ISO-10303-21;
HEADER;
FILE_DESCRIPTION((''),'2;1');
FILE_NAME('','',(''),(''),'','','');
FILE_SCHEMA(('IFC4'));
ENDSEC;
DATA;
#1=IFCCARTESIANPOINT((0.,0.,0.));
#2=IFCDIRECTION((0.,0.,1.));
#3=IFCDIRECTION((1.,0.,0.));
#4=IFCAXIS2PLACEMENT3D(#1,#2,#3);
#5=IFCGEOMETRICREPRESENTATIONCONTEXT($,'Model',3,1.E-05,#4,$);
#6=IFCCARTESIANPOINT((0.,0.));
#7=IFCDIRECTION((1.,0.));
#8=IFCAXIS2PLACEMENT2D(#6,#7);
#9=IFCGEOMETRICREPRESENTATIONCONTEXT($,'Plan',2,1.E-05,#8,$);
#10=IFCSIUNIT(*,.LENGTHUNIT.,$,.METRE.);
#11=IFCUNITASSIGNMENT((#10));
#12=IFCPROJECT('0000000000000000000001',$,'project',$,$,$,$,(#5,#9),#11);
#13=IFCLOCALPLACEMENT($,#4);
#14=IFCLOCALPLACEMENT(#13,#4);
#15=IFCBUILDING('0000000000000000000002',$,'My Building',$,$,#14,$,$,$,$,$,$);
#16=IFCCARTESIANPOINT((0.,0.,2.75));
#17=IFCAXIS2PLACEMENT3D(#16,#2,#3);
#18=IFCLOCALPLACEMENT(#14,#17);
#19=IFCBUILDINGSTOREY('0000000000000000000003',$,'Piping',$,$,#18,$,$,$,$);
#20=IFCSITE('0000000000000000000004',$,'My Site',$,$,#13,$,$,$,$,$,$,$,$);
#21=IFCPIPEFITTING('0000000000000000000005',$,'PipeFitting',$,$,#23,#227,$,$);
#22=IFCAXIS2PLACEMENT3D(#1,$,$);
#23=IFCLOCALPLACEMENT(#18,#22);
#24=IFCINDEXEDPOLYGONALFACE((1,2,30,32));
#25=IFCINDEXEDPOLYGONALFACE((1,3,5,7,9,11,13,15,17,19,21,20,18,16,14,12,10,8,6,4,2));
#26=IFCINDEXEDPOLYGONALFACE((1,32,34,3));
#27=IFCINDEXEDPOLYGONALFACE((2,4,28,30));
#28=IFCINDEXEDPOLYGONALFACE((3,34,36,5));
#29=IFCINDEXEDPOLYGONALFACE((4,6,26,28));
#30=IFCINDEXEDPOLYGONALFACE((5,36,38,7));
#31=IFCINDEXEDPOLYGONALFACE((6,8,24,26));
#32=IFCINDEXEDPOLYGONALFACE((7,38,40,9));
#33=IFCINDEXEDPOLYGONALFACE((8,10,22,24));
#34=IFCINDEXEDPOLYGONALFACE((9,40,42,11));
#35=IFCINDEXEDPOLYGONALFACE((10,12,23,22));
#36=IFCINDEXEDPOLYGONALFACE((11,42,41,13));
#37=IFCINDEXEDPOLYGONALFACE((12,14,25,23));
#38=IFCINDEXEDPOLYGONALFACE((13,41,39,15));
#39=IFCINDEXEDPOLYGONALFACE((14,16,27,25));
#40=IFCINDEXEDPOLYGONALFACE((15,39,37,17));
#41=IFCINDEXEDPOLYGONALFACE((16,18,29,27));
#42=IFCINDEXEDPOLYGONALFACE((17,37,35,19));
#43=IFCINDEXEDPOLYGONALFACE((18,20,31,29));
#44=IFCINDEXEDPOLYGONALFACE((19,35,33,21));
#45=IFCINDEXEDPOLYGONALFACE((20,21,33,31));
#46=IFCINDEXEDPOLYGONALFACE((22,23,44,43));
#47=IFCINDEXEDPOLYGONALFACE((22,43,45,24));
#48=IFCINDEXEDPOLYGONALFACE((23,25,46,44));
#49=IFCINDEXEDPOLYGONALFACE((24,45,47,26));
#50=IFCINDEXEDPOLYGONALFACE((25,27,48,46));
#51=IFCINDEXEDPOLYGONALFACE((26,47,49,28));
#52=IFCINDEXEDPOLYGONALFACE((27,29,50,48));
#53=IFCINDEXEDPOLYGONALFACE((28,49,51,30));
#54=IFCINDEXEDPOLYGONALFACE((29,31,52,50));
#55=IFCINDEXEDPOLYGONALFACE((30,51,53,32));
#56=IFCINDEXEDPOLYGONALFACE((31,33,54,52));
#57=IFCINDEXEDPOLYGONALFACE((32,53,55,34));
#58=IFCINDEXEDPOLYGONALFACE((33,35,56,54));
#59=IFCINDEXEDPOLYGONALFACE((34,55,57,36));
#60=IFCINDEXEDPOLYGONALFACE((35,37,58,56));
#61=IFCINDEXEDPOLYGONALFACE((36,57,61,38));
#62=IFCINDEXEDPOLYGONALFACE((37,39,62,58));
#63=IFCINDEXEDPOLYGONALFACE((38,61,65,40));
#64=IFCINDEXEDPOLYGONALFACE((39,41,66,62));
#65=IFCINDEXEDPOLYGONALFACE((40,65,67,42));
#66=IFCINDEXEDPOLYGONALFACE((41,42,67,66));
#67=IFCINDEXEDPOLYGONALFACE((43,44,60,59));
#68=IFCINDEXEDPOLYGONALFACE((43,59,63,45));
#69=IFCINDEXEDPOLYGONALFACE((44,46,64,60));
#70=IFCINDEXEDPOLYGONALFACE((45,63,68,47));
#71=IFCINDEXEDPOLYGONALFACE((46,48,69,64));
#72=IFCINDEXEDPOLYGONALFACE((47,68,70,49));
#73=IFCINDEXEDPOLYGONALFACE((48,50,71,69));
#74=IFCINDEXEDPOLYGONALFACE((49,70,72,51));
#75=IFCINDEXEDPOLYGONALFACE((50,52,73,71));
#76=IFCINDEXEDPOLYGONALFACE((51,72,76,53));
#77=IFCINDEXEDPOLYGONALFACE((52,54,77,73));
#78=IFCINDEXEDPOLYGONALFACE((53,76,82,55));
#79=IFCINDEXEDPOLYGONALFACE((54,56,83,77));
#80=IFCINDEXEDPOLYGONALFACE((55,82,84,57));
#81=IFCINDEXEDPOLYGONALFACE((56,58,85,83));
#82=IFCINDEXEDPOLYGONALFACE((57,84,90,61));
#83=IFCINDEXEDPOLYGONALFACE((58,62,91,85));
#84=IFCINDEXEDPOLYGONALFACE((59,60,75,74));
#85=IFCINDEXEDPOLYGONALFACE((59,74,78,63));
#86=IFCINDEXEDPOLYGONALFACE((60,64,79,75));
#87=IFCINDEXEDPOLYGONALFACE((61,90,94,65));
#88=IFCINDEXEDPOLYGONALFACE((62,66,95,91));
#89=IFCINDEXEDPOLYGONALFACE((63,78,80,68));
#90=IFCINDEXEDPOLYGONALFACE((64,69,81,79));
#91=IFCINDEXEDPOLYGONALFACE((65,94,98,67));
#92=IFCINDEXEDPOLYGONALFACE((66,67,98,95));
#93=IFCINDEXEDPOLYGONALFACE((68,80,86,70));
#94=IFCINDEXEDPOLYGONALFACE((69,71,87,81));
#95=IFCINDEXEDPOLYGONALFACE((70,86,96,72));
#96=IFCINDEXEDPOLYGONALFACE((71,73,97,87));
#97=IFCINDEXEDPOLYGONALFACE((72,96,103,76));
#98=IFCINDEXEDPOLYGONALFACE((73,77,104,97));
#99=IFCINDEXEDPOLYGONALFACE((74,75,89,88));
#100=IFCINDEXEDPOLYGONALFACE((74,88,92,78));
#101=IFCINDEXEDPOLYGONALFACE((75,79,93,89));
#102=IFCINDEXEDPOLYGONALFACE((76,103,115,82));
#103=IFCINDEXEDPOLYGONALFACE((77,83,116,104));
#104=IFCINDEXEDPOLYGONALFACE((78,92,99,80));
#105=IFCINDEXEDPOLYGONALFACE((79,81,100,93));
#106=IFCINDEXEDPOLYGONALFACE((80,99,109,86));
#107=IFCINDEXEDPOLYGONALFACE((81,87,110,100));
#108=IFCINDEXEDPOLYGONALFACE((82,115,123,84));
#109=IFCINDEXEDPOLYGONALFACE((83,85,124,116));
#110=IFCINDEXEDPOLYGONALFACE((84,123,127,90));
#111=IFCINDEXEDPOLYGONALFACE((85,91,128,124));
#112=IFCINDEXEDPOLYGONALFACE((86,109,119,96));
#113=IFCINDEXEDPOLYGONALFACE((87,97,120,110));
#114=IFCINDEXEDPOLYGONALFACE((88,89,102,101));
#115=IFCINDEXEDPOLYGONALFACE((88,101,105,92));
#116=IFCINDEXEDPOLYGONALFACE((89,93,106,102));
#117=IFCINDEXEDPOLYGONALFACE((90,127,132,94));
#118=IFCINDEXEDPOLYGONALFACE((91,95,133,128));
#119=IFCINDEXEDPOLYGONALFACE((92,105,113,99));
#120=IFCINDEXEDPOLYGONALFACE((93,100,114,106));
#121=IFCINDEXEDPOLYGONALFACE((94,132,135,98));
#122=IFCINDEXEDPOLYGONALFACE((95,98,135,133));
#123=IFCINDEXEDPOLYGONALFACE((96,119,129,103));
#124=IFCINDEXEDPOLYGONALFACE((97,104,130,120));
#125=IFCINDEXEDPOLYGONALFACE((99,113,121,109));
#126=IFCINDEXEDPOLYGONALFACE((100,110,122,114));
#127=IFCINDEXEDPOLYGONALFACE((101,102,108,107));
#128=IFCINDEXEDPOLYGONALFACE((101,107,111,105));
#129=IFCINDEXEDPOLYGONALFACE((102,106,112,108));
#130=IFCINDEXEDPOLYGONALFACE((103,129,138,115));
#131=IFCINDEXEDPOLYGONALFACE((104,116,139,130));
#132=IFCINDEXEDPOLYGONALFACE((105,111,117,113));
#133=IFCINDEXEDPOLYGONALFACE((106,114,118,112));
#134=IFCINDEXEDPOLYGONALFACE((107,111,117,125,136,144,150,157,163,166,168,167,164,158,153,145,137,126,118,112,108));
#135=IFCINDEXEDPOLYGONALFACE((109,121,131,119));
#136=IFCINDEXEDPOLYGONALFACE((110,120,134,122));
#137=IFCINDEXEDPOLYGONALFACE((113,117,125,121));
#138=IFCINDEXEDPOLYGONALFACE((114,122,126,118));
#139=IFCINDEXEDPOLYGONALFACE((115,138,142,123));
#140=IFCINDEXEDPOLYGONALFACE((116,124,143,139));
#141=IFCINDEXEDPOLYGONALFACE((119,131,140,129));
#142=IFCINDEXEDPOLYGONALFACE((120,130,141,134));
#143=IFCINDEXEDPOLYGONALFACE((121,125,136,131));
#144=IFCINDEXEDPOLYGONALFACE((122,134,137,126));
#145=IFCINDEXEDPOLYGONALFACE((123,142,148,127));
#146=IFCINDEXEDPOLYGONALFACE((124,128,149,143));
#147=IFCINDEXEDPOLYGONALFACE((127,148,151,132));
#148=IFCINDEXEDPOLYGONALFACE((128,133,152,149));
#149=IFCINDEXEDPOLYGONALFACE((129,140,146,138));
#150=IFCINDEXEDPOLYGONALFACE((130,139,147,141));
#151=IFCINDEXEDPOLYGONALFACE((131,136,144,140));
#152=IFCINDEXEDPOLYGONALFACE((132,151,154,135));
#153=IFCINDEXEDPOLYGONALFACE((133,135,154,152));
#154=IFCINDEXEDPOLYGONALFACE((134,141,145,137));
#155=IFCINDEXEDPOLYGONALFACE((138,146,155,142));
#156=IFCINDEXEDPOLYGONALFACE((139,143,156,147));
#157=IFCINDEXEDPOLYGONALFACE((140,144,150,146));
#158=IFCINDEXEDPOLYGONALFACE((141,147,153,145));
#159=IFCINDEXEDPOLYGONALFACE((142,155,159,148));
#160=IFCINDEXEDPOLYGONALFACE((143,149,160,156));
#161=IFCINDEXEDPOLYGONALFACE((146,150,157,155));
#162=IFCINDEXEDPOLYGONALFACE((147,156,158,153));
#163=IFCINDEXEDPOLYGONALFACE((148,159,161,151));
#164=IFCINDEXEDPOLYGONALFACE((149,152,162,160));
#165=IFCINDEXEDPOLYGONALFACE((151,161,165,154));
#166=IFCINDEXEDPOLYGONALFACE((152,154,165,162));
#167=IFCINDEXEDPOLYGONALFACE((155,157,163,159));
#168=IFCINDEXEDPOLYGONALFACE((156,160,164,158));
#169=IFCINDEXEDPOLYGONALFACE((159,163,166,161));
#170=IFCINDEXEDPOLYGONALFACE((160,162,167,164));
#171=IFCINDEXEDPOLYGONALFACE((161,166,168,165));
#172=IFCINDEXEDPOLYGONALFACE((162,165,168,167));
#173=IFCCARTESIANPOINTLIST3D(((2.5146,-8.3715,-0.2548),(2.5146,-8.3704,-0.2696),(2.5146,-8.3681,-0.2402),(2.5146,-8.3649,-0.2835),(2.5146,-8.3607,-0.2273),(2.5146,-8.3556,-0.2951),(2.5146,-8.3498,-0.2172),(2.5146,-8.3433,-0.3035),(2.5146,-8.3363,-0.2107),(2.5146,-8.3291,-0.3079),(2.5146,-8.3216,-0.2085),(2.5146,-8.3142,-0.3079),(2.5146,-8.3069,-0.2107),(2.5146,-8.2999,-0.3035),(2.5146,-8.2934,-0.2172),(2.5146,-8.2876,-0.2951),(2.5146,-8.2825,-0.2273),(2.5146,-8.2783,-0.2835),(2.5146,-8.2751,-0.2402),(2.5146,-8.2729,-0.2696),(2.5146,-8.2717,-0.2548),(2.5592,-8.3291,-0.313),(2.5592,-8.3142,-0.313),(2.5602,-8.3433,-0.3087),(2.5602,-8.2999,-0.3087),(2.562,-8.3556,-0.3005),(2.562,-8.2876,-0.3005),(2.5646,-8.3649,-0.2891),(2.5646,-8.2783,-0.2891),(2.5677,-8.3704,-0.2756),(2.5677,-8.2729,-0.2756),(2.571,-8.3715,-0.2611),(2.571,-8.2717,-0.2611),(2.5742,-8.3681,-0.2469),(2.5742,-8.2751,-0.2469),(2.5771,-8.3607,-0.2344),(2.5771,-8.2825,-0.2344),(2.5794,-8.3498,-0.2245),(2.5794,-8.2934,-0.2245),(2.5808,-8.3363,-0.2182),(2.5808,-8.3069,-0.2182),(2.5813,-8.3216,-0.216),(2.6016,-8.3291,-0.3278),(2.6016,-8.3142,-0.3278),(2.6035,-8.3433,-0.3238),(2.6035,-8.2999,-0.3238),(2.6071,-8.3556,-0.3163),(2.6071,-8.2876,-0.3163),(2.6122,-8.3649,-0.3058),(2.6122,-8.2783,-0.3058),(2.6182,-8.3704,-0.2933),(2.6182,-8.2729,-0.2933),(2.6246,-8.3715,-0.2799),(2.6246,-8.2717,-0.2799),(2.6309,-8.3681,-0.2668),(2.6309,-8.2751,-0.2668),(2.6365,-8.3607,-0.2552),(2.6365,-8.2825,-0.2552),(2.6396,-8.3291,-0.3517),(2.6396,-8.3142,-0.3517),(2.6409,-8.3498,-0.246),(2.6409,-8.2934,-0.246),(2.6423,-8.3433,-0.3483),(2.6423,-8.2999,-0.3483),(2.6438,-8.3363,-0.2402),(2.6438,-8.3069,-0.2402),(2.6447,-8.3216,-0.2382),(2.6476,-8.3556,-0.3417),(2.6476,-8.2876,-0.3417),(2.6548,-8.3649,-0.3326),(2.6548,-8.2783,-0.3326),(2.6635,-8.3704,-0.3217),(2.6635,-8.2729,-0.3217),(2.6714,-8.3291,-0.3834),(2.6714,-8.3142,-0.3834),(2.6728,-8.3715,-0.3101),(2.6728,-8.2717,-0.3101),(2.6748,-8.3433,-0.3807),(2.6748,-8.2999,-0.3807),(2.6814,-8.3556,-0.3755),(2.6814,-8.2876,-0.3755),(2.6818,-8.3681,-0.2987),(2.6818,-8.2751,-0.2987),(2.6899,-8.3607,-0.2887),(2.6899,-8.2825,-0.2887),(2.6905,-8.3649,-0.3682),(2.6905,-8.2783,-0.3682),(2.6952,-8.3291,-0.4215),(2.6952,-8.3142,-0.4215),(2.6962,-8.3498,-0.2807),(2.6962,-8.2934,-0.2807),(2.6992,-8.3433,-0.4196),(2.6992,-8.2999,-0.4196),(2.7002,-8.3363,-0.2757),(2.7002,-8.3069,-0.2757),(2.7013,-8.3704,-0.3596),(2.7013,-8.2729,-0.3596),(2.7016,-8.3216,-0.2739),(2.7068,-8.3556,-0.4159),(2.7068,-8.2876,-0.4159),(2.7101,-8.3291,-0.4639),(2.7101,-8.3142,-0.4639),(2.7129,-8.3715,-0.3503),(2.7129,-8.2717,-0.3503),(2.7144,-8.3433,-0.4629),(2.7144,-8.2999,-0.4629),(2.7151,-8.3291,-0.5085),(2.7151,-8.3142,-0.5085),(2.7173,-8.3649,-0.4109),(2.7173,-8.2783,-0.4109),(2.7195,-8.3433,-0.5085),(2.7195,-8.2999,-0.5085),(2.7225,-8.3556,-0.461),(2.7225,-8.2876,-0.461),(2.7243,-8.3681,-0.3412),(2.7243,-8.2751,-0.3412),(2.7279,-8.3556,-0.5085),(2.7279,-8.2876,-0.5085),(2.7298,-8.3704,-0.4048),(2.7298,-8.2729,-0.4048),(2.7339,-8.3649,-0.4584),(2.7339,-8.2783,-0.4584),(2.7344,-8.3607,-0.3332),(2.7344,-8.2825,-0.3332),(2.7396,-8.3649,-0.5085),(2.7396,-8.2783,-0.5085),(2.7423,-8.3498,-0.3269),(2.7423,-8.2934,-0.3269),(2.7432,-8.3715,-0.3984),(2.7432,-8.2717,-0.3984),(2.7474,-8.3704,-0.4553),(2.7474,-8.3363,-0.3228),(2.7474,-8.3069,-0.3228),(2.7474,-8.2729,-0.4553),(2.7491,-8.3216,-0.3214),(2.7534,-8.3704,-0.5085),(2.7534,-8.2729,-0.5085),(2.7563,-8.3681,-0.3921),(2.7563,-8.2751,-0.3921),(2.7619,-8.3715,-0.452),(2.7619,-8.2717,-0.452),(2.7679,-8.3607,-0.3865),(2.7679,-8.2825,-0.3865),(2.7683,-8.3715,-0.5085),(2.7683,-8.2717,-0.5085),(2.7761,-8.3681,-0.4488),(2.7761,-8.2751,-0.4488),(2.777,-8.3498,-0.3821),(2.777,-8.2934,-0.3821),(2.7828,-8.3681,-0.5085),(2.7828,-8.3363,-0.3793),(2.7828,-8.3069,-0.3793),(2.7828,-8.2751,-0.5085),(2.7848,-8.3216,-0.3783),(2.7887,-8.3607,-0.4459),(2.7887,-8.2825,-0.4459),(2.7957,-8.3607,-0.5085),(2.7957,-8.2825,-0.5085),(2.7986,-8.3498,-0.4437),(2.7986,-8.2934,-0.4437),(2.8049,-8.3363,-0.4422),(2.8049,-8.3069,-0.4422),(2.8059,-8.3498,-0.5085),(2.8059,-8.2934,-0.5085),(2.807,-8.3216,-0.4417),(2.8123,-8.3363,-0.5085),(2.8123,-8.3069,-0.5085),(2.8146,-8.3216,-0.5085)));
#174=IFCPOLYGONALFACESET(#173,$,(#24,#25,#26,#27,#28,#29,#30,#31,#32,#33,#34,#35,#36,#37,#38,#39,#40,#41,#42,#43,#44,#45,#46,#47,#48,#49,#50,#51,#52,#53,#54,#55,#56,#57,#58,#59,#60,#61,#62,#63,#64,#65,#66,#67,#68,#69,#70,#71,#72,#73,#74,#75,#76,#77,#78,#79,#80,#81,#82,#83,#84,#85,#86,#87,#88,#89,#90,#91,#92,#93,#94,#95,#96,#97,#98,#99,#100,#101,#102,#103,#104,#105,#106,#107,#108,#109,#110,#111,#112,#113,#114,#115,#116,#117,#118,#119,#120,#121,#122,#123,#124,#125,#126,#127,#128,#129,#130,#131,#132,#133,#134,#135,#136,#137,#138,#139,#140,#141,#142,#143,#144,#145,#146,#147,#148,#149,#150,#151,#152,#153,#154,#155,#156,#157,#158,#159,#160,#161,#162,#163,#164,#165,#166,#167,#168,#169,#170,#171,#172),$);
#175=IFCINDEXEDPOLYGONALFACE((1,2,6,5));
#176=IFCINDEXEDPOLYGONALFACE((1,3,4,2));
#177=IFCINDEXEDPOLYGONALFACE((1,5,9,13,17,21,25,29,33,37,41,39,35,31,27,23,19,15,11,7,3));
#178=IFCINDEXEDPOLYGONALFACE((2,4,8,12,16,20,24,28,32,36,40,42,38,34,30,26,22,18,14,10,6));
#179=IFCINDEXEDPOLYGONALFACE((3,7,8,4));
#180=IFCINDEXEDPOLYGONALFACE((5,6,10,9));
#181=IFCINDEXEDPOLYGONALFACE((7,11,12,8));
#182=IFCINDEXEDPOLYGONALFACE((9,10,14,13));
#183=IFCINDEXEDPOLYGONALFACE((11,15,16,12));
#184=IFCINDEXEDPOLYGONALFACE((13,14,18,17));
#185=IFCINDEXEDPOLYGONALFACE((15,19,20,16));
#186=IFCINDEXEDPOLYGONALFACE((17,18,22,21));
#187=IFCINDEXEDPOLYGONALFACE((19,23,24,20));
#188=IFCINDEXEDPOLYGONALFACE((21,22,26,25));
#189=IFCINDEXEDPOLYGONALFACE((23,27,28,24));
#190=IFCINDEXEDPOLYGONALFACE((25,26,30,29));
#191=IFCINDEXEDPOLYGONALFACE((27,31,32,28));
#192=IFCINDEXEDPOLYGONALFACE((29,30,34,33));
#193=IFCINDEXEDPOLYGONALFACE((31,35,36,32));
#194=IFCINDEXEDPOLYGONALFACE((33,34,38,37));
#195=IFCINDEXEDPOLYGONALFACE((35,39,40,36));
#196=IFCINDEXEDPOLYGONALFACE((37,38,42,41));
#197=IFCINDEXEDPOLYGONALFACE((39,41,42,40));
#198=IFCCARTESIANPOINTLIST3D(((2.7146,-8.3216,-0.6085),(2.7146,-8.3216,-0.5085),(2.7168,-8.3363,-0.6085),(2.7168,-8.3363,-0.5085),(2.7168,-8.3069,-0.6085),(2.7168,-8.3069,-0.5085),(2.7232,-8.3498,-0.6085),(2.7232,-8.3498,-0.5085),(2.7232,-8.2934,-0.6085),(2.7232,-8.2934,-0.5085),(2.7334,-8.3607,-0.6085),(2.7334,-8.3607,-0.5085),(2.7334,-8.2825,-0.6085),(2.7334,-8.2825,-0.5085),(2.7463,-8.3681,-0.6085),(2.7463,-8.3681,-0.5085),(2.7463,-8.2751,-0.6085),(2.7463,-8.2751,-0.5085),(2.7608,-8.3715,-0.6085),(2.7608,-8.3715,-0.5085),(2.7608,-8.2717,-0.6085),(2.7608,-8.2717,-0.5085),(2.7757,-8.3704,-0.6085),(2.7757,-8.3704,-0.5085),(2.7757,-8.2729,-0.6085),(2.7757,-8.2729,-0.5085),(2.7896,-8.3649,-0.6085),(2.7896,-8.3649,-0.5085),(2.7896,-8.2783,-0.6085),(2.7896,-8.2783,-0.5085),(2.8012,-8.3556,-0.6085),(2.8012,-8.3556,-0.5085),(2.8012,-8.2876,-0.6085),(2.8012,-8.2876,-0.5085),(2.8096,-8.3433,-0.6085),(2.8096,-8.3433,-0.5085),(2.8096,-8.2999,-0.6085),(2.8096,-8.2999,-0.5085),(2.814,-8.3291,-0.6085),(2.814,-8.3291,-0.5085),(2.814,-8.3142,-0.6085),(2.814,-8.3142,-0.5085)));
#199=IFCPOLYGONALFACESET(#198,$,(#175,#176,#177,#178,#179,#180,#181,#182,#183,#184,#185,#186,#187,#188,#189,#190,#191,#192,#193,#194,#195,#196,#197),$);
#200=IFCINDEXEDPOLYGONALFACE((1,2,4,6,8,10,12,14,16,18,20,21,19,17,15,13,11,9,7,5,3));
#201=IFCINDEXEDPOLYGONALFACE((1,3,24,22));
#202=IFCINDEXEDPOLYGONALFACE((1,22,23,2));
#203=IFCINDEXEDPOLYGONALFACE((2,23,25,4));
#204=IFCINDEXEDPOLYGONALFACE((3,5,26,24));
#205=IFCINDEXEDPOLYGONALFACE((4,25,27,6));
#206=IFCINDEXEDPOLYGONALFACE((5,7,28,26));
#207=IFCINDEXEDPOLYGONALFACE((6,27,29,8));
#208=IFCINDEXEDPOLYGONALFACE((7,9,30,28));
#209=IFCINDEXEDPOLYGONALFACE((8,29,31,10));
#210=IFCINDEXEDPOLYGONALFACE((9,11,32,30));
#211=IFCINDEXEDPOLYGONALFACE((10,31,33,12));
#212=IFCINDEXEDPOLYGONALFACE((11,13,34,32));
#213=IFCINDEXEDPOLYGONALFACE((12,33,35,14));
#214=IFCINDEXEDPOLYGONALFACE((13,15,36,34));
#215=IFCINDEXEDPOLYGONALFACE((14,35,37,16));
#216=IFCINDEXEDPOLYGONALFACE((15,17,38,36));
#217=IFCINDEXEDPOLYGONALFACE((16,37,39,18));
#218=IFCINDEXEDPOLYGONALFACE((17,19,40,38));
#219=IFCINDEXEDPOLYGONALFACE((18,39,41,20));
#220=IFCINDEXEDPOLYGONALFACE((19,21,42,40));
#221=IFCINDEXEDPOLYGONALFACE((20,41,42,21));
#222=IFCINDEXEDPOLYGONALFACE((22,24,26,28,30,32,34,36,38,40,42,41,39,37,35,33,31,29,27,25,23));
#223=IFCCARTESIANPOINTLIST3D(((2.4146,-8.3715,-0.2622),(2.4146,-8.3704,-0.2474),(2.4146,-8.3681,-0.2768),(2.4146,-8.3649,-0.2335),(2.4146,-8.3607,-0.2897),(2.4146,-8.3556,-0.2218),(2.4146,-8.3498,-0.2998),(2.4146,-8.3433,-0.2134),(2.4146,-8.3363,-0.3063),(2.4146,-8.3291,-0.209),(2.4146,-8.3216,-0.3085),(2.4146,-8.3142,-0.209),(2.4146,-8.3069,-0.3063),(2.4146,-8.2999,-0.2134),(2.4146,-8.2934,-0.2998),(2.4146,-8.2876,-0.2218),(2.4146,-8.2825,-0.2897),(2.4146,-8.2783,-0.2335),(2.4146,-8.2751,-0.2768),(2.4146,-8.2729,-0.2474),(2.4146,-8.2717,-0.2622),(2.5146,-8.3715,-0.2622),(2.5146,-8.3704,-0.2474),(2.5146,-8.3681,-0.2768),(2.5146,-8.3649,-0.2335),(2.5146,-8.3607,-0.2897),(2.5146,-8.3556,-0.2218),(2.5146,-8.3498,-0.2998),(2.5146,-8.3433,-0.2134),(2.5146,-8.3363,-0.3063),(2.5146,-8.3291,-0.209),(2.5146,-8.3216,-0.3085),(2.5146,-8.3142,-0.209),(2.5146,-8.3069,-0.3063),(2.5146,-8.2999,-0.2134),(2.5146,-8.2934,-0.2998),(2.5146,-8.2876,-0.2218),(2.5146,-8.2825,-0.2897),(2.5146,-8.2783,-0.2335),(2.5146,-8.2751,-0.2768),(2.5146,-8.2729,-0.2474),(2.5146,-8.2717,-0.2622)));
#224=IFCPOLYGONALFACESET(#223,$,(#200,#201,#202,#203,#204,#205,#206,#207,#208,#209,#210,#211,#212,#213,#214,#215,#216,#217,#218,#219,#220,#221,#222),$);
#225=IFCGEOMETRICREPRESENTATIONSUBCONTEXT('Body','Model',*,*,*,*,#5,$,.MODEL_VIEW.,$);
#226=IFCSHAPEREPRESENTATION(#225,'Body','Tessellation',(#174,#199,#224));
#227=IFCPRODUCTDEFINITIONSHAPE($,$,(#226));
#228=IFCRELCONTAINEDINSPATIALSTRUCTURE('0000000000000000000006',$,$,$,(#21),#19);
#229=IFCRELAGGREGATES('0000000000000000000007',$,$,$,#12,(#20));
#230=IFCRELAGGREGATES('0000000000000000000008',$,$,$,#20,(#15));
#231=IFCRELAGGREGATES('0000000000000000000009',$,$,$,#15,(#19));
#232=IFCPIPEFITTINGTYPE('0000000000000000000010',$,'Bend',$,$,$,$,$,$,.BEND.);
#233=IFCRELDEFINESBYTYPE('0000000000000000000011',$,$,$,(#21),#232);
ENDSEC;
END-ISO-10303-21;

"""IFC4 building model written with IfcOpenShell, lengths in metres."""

from ifc_helpers import new_model, entity, si_unit, frame, origin_with_axes, origin_2d_with_axis, place, context, subcontext, project, spatial, circle, extrude, source, transform, mapped, type_object, type_shapes, element, save


model = new_model("IFC4")

# Units and contexts
model_context = context("Model", 3, precision=1e-05, world=origin_with_axes())
plan_context = context("Plan", 2, precision=1e-05, world=origin_2d_with_axis())
body_context = subcontext(model_context, "Body", "Model", "MODEL_VIEW")
ifc_project = project(units=[si_unit("LENGTHUNIT", "METRE")], contexts=[model_context, plan_context])

# Site, building, storey
site_placement = place(None, origin_with_axes())
site = spatial("IfcSite", under=ifc_project, at=site_placement, Name="My Site")
building_placement = place(site_placement, origin_with_axes())
building = spatial("IfcBuilding", under=site, at=building_placement, Name="My Building")
storey_placement = place(building_placement, frame((0.0, 0.0, 2.75), z_axis=(0.0, 0.0, 1.0), x_axis=(1.0, 0.0, 0.0)))
storey = spatial("IfcBuildingStorey", under=building, at=storey_placement, Name="Piping")

# Pipe fitting
pipe_fitting_type = type_object("IfcPipeFittingType", Name="Bend", PredefinedType="BEND")
shared_shape = source(origin_with_axes(), body_context, "Body", "SolidModel", [
    entity("IfcSweptDiskSolid", entity("IfcIndexedPolyCurve", entity("IfcCartesianPointList3D", [[0.0, 0.0, -0.1], [0.0732, 0.0, -0.2768], [0.25, 0.0, -0.35]]), [entity("IfcArcIndex", [1, 2, 3])]), 0.05),
    extrude(circle(Radius=0.05), origin_with_axes(), (0.0, 0.0, -1.0), 0.1),
    extrude(circle(Radius=0.05), frame((0.25, 0.0, -0.35), z_axis=(1.0, 0.0, 0.0), x_axis=(0.0, 0.0, 1.0)), (0.0, 0.0, 1.0), 0.1),
])
type_shapes(pipe_fitting_type, [shared_shape])
for number, where, z_axis, x_axis, name in (
    (1, (2.7646, -8.3216, -0.6085), (0.0, 0.0, -1.0), (-1.0, 0.0, 0.0), "PipeFitting"),
):
    element("IfcPipeFitting", number, at=place(storey_placement, frame(where, z_axis=z_axis, x_axis=x_axis)), inside=storey, type_object=pipe_fitting_type, Name=name, context=body_context, shape_type="MappedRepresentation", body=[
        mapped(shared_shape, transform((0.0, 0.0, 0.0), x_axis=(1.0, 0.0, 0.0), y_axis=(0.0, 1.0, 0.0), z_axis=(0.0, 0.0, 1.0), scale=1.0)),
    ])

save(model, "model.ifc")
